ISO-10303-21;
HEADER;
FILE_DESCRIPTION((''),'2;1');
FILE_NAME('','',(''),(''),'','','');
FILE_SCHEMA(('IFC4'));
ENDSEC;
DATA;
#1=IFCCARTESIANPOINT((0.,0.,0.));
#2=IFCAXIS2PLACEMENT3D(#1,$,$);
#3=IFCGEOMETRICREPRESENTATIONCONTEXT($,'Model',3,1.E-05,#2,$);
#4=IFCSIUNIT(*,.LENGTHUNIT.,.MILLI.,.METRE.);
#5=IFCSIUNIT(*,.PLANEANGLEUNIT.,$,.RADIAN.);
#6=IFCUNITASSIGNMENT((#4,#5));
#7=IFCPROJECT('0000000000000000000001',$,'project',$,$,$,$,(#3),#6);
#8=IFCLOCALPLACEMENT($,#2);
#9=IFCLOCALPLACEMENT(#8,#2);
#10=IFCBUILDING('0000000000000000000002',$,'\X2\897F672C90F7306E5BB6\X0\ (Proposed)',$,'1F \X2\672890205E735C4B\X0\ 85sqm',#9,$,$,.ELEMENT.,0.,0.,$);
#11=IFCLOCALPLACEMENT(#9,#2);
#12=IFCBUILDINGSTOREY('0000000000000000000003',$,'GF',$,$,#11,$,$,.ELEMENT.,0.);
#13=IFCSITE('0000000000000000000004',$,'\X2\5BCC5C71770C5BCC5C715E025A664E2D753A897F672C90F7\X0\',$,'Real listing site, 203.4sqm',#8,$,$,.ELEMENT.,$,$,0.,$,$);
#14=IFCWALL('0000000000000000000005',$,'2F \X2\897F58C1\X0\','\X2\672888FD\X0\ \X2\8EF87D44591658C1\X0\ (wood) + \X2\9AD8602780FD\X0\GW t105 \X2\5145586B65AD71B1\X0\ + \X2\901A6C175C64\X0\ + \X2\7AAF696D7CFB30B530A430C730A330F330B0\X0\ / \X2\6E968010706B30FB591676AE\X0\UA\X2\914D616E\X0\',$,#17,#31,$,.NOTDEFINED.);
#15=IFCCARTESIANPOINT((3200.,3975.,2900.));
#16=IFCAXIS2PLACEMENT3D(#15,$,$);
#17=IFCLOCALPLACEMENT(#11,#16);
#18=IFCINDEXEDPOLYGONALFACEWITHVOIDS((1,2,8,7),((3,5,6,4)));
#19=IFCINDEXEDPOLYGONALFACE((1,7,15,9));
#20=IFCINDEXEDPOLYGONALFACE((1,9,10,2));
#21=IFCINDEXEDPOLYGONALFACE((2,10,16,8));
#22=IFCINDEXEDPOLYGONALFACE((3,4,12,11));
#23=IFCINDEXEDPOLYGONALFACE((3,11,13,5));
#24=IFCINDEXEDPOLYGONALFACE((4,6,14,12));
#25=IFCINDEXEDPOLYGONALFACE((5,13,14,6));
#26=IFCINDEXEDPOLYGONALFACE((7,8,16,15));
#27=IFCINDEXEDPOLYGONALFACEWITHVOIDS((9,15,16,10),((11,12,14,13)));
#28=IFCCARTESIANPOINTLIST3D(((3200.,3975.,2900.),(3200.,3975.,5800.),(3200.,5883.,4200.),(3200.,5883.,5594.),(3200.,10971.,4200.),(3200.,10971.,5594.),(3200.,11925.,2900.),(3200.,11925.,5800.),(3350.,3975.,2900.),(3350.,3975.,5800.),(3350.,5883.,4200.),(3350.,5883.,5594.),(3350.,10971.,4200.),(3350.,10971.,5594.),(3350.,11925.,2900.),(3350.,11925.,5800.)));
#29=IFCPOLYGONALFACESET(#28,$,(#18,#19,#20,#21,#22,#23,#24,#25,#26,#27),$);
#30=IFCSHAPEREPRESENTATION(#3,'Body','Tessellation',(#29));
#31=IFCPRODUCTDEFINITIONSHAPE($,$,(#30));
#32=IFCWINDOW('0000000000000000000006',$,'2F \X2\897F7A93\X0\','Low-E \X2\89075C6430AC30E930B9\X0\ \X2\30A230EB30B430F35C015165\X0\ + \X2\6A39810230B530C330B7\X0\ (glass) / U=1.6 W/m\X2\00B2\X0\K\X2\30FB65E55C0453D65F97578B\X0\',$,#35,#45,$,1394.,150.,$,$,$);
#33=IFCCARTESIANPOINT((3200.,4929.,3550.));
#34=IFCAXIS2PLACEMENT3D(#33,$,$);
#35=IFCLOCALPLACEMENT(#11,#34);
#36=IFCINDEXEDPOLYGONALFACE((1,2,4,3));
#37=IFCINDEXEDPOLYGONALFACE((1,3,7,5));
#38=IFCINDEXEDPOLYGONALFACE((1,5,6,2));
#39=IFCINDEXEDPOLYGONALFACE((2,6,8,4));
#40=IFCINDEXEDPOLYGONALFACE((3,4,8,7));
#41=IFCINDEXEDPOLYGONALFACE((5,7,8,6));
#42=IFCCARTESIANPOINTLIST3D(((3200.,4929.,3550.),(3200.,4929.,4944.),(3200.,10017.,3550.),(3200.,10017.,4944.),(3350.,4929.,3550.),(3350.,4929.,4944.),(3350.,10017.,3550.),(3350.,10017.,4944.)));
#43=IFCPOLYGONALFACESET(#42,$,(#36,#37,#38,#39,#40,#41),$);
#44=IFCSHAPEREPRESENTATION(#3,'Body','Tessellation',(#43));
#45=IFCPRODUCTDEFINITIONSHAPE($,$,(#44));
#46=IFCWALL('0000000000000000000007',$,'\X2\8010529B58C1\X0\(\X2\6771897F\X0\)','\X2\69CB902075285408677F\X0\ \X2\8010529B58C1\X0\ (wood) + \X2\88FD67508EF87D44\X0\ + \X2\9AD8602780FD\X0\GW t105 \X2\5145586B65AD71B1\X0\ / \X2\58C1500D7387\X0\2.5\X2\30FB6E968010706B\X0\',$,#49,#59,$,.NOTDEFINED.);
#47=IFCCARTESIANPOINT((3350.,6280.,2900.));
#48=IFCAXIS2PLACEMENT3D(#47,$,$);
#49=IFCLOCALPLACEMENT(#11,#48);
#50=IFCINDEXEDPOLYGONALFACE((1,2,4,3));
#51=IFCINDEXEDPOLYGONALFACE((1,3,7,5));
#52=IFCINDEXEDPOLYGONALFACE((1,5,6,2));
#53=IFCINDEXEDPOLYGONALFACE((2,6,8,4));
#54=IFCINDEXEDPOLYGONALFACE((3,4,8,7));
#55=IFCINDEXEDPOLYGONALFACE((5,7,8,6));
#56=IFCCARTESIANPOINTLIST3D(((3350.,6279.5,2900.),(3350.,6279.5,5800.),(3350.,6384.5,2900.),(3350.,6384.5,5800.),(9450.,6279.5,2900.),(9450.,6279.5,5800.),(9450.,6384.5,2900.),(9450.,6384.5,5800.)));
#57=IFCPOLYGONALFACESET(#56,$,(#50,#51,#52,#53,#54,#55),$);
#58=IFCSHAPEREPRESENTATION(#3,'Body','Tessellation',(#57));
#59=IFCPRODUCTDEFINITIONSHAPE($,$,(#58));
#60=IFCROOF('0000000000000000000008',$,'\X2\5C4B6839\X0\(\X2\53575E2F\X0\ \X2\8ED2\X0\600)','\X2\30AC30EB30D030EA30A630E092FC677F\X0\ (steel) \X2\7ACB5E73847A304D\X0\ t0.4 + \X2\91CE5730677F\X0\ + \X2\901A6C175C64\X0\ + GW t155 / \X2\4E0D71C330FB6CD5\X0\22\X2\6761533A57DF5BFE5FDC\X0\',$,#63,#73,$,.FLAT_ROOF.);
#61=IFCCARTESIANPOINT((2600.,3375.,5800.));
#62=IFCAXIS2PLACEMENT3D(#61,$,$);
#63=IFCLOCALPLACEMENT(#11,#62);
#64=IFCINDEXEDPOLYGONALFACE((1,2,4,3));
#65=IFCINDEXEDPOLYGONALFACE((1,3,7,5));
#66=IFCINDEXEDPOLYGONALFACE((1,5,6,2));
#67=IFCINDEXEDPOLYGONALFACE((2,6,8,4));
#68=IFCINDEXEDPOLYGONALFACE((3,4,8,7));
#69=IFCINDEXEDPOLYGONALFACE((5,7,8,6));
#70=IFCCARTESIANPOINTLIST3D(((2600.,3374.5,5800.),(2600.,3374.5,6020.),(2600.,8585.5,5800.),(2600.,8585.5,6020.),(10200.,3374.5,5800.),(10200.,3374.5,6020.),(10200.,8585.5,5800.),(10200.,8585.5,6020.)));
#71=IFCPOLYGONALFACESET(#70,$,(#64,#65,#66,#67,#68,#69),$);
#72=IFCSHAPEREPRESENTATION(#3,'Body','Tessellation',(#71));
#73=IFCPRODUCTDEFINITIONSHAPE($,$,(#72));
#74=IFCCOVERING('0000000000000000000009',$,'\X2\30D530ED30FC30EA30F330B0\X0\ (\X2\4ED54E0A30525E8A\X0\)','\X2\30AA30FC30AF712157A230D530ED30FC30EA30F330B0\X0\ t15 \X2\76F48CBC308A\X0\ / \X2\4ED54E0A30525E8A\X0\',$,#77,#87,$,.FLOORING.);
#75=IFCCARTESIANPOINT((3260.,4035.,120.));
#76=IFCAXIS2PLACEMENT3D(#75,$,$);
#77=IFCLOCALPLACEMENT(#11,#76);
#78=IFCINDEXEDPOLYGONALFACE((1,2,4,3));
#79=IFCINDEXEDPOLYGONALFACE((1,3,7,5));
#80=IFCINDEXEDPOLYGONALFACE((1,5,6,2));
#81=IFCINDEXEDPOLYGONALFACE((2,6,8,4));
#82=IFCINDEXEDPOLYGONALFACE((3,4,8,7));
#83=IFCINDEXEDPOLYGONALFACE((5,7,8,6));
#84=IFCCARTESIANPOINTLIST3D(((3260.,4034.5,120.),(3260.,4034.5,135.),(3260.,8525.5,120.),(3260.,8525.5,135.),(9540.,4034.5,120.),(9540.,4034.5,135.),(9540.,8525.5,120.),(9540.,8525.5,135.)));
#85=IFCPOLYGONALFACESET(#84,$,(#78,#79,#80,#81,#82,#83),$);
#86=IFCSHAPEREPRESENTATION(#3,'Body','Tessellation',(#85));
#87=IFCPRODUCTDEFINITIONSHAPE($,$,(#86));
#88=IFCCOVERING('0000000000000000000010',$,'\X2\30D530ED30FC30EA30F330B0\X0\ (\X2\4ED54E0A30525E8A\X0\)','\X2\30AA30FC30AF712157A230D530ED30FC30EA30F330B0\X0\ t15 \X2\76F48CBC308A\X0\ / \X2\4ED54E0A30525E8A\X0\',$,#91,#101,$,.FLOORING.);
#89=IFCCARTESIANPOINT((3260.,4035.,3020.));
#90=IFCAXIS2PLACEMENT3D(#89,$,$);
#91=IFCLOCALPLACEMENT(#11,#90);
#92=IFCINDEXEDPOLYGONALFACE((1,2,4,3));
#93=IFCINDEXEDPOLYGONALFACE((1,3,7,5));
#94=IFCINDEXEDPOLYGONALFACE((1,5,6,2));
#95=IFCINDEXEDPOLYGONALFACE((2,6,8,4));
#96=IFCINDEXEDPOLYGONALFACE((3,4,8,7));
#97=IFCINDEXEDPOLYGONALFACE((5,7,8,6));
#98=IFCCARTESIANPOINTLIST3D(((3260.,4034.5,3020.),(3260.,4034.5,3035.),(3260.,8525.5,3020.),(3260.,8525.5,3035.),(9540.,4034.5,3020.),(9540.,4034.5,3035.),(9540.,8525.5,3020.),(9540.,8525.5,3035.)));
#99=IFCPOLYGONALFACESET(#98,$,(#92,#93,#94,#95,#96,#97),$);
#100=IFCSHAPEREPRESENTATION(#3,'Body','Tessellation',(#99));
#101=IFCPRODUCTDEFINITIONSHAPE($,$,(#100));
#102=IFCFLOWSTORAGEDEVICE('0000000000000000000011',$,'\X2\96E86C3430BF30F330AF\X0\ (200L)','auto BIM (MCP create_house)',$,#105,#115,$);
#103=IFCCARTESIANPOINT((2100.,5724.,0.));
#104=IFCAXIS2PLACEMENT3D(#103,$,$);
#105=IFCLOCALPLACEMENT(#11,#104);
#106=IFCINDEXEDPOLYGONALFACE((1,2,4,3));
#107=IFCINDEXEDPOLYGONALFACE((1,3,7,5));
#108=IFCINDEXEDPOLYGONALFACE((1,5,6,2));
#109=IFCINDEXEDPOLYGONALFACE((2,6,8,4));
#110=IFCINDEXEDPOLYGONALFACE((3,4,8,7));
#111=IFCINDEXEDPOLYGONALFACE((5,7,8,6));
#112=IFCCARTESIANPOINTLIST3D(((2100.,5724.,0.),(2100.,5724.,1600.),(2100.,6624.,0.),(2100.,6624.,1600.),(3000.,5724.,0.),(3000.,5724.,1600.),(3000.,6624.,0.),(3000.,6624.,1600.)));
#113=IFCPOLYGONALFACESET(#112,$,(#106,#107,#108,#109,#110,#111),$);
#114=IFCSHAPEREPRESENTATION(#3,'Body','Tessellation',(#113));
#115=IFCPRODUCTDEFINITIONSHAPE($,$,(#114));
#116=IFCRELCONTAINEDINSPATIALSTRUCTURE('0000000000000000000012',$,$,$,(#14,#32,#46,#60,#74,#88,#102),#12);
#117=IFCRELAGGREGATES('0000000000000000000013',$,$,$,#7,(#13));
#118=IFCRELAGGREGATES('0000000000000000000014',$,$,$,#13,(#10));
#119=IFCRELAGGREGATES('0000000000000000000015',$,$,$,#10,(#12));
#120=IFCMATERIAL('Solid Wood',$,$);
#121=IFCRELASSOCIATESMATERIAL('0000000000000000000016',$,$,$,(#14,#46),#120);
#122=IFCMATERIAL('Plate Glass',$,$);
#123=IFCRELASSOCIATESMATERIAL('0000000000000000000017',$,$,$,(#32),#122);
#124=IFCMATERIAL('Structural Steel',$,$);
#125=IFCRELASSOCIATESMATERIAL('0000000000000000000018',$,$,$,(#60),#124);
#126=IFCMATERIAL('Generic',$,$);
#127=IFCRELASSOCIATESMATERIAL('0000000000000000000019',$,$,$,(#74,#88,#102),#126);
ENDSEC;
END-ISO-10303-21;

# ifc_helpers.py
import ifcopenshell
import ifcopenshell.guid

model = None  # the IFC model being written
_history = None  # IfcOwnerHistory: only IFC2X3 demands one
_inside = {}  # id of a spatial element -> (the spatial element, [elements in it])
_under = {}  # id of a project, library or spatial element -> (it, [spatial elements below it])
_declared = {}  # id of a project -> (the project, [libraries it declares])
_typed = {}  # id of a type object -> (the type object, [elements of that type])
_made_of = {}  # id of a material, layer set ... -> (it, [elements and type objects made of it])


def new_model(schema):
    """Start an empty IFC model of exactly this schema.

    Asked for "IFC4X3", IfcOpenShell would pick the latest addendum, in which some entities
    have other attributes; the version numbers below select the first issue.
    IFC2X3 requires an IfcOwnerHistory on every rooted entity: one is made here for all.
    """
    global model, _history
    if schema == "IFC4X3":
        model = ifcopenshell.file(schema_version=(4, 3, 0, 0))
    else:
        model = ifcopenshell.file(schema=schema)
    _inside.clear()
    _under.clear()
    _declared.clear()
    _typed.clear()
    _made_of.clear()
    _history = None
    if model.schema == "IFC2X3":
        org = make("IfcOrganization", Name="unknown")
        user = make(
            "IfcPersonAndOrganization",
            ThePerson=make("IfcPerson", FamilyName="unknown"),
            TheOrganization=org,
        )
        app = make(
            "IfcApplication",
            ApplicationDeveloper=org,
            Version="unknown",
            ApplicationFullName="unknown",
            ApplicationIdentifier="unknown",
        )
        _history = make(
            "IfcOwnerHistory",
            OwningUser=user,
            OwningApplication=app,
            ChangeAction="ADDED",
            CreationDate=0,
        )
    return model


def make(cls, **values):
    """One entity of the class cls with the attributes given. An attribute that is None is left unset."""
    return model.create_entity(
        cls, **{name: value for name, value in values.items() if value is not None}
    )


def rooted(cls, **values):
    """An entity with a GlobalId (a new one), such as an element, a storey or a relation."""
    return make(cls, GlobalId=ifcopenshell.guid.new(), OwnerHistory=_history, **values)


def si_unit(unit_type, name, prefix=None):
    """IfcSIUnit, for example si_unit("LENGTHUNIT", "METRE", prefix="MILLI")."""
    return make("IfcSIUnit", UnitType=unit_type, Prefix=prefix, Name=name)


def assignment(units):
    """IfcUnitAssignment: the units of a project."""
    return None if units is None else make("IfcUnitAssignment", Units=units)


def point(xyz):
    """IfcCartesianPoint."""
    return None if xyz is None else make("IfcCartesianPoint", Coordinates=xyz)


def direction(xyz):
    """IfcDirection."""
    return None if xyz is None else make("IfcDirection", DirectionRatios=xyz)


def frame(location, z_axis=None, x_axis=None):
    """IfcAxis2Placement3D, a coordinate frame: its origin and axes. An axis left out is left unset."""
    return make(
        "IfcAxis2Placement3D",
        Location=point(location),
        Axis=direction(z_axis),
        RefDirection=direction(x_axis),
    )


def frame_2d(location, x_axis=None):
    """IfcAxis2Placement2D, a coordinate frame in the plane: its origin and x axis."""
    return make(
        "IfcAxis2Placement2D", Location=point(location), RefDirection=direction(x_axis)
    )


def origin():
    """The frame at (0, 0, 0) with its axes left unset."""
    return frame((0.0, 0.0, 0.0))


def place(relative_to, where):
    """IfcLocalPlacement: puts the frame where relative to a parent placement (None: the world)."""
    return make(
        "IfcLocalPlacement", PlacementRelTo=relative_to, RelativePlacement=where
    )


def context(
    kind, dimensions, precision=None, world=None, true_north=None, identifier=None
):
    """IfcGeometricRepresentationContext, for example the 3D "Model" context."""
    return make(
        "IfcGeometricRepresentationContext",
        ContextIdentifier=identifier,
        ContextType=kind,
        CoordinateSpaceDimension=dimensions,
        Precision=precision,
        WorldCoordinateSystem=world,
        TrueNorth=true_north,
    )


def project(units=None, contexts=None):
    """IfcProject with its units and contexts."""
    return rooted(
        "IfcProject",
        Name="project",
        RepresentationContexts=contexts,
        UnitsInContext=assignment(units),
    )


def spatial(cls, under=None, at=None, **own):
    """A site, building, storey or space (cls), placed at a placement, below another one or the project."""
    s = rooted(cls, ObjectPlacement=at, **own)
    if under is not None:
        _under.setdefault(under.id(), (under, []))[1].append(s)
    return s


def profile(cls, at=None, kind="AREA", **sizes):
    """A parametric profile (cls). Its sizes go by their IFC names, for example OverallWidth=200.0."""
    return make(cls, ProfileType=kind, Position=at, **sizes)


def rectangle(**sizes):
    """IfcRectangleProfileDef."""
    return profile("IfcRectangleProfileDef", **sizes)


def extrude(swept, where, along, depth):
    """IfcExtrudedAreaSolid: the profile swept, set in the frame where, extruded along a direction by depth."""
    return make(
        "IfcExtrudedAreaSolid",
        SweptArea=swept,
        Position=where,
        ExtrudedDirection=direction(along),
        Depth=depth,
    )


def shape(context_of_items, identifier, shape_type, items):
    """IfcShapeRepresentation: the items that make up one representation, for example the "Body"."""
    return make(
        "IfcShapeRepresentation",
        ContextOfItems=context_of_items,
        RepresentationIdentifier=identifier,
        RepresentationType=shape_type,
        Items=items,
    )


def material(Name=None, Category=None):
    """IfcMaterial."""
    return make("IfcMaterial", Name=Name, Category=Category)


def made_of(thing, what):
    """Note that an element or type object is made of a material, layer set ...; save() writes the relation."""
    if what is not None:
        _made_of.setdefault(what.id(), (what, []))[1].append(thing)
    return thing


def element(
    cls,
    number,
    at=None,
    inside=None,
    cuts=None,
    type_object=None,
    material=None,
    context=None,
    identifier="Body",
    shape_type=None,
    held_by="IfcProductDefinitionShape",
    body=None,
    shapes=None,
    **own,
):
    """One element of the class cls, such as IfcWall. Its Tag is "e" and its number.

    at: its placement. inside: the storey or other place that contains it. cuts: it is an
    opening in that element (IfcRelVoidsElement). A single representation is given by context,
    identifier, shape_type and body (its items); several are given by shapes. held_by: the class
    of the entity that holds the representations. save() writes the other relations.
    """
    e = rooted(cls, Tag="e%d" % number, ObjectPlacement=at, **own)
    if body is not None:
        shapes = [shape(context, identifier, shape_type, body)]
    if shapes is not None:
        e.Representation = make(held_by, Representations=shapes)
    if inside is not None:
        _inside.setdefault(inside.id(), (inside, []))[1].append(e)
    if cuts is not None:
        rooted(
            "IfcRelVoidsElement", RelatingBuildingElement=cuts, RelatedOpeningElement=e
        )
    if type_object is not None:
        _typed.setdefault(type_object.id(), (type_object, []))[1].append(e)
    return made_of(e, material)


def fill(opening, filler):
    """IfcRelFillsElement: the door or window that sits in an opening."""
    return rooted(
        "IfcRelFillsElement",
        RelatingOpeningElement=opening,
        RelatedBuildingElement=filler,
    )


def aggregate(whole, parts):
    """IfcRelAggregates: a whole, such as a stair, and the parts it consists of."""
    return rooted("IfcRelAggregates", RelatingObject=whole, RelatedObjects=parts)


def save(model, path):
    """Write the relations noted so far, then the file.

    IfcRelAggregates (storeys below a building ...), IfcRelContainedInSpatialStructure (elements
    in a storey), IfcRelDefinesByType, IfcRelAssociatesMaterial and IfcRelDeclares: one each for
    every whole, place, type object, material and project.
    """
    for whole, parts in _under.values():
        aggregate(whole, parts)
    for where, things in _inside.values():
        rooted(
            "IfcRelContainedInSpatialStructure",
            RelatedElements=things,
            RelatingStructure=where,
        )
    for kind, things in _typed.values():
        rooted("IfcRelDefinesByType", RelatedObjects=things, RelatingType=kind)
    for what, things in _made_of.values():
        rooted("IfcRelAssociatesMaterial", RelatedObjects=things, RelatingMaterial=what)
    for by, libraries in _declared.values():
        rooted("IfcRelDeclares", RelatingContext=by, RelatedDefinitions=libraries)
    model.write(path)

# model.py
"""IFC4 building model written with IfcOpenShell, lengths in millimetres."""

from ifc_helpers import new_model, si_unit, frame, frame_2d, origin, place, context, project, spatial, rectangle, extrude, material, element, fill, save


model = new_model("IFC4")

# Units and contexts
model_context = context("Model", 3, precision=1e-05, world=origin())
ifc_project = project(units=[si_unit("LENGTHUNIT", "METRE", prefix="MILLI"), si_unit("PLANEANGLEUNIT", "RADIAN")], contexts=[model_context])

# Site, building, storey
site_placement = place(None, origin())
site = spatial("IfcSite", under=ifc_project, at=site_placement, Name="富山県富山市婦中町西本郷", ObjectType="Real listing site, 203.4sqm", CompositionType="ELEMENT", RefElevation=0.0)
building_placement = place(site_placement, origin())
building = spatial("IfcBuilding", under=site, at=building_placement, Name="西本郷の家 (Proposed)", ObjectType="1F 木造平屋 85sqm", CompositionType="ELEMENT", ElevationOfRefHeight=0.0, ElevationOfTerrain=0.0)
storey_placement = place(building_placement, origin())
storey = spatial("IfcBuildingStorey", under=building, at=storey_placement, Name="GF", CompositionType="ELEMENT", Elevation=0.0)

# Shared definitions
ifc_material_1 = material(Name="Solid Wood")
ifc_material_2 = material(Name="Generic")

# Shared definitions
ifc_material_3 = material(Name="Plate Glass")

# Wall, opening, window
wall_1_placement = place(storey_placement, frame((3200.0, 3975.0, 2900.0)))
wall_1 = element("IfcWall", 1, at=wall_1_placement, inside=storey, material=ifc_material_1, Name="2F 西壁", Description="木製 軸組外壁 (wood) + 高性能GW t105 充填断熱 + 通気層 + 窯業系サイディング / 準耐火・外皮UA配慮", PredefinedType="NOTDEFINED", context=model_context, shape_type="SweptSolid", body=[
    extrude(rectangle(XDim=150.0, YDim=7950.0, at=frame_2d((75.0, 3975.0))), frame((3200.0, 3975.0, 2900.0)), (0.0, 0.0, 1.0), 2900.0),
])
opening_1_placement = place(storey_placement, frame((3200.0, 4929.0, 3550.0)))
opening_1 = element("IfcOpeningElement", 2, at=opening_1_placement, cuts=wall_1, PredefinedType="NOTDEFINED", context=model_context, shape_type="SweptSolid", body=[
    extrude(rectangle(XDim=150.0, YDim=5088.0, at=frame_2d((75.0, 2544.0))), frame((3200.0, 4929.0, 3550.0)), (0.0, 0.0, 1.0), 1394.0),
])
window_1_placement = place(storey_placement, frame((3200.0, 4929.0, 3550.0)))
window_1 = element("IfcWindow", 3, at=window_1_placement, inside=storey, material=ifc_material_3, Name="2F 西窓", Description="Low-E 複層ガラス アルゴン封入 + 樹脂サッシ (glass) / U=1.6 W/m²K・日射取得型", OverallHeight=1394.0, OverallWidth=150.0, context=model_context, shape_type="SweptSolid", body=[
    extrude(rectangle(XDim=150.0, YDim=5088.0, at=frame_2d((75.0, 2544.0))), frame((3200.0, 4929.0, 3550.0)), (0.0, 0.0, 1.0), 1394.0),
])
fill(opening_1, window_1)

# Wall
wall_2_placement = place(storey_placement, frame((3350.0, 6280.0, 2900.0)))
element("IfcWall", 4, at=wall_2_placement, inside=storey, material=ifc_material_1, Name="耐力壁(東西)", Description="構造用合板 耐力壁 (wood) + 製材軸組 + 高性能GW t105 充填断熱 / 壁倍率2.5・準耐火", PredefinedType="NOTDEFINED", context=model_context, shape_type="SweptSolid", body=[
    extrude(rectangle(XDim=6100.0, YDim=105.0, at=frame_2d((3050.0, 52.0))), frame((3350.0, 6280.0, 2900.0)), (0.0, 0.0, 1.0), 2900.0),
])

# Roof
ifc_material_4 = material(Name="Structural Steel")
for number, where, name in (
    (5, (2600.0, 3375.0, 5800.0), "屋根(南帯 軒600)"),
):
    element("IfcRoof", number, at=place(storey_placement, frame(where)), inside=storey, material=ifc_material_4, Name=name, Description="ガルバリウム鋼板 (steel) 立平葺き t0.4 + 野地板 + 通気層 + GW t155 / 不燃・法22条区域対応", PredefinedType="FLAT_ROOF", context=model_context, shape_type="SweptSolid", body=[
        extrude(rectangle(XDim=7600.0, YDim=5211.0, at=frame_2d((3800.0, 2605.0))), frame((2600.0, 3375.0, 5800.0)), (0.0, 0.0, 1.0), 220.0),
    ])

# Coverings
covering_1_placement = place(storey_placement, frame((3260.0, 4035.0, 120.0)))
element("IfcCovering", 6, at=covering_1_placement, inside=storey, material=ifc_material_2, Name="フローリング (仕上げ床)", Description="オーク無垢フローリング t15 直貼り / 仕上げ床", PredefinedType="FLOORING", context=model_context, shape_type="SweptSolid", body=[
    extrude(rectangle(XDim=6280.0, YDim=4491.0, at=frame_2d((3140.0, 2245.0))), frame((3260.0, 4035.0, 120.0)), (0.0, 0.0, 1.0), 15.0),
])
covering_2_placement = place(storey_placement, frame((3260.0, 4035.0, 3020.0)))
element("IfcCovering", 7, at=covering_2_placement, inside=storey, material=ifc_material_2, Name="フローリング (仕上げ床)", Description="オーク無垢フローリング t15 直貼り / 仕上げ床", PredefinedType="FLOORING", context=model_context, shape_type="SweptSolid", body=[
    extrude(rectangle(XDim=6280.0, YDim=4491.0, at=frame_2d((3140.0, 2245.0))), frame((3260.0, 4035.0, 3020.0)), (0.0, 0.0, 1.0), 15.0),
])

# Flow storage device
flow_storage_device_placement = place(storey_placement, frame((2100.0, 5724.0, 0.0)))
element("IfcFlowStorageDevice", 8, at=flow_storage_device_placement, inside=storey, material=ifc_material_2, Name="雨水タンク (200L)", Description="auto BIM (MCP create_house)", context=model_context, shape_type="SweptSolid", body=[
    extrude(rectangle(XDim=900.0, YDim=900.0, at=frame_2d((450.0, 450.0))), frame((2100.0, 5724.0, 0.0)), (0.0, 0.0, 1.0), 1600.0),
])

save(model, "model.ifc")
